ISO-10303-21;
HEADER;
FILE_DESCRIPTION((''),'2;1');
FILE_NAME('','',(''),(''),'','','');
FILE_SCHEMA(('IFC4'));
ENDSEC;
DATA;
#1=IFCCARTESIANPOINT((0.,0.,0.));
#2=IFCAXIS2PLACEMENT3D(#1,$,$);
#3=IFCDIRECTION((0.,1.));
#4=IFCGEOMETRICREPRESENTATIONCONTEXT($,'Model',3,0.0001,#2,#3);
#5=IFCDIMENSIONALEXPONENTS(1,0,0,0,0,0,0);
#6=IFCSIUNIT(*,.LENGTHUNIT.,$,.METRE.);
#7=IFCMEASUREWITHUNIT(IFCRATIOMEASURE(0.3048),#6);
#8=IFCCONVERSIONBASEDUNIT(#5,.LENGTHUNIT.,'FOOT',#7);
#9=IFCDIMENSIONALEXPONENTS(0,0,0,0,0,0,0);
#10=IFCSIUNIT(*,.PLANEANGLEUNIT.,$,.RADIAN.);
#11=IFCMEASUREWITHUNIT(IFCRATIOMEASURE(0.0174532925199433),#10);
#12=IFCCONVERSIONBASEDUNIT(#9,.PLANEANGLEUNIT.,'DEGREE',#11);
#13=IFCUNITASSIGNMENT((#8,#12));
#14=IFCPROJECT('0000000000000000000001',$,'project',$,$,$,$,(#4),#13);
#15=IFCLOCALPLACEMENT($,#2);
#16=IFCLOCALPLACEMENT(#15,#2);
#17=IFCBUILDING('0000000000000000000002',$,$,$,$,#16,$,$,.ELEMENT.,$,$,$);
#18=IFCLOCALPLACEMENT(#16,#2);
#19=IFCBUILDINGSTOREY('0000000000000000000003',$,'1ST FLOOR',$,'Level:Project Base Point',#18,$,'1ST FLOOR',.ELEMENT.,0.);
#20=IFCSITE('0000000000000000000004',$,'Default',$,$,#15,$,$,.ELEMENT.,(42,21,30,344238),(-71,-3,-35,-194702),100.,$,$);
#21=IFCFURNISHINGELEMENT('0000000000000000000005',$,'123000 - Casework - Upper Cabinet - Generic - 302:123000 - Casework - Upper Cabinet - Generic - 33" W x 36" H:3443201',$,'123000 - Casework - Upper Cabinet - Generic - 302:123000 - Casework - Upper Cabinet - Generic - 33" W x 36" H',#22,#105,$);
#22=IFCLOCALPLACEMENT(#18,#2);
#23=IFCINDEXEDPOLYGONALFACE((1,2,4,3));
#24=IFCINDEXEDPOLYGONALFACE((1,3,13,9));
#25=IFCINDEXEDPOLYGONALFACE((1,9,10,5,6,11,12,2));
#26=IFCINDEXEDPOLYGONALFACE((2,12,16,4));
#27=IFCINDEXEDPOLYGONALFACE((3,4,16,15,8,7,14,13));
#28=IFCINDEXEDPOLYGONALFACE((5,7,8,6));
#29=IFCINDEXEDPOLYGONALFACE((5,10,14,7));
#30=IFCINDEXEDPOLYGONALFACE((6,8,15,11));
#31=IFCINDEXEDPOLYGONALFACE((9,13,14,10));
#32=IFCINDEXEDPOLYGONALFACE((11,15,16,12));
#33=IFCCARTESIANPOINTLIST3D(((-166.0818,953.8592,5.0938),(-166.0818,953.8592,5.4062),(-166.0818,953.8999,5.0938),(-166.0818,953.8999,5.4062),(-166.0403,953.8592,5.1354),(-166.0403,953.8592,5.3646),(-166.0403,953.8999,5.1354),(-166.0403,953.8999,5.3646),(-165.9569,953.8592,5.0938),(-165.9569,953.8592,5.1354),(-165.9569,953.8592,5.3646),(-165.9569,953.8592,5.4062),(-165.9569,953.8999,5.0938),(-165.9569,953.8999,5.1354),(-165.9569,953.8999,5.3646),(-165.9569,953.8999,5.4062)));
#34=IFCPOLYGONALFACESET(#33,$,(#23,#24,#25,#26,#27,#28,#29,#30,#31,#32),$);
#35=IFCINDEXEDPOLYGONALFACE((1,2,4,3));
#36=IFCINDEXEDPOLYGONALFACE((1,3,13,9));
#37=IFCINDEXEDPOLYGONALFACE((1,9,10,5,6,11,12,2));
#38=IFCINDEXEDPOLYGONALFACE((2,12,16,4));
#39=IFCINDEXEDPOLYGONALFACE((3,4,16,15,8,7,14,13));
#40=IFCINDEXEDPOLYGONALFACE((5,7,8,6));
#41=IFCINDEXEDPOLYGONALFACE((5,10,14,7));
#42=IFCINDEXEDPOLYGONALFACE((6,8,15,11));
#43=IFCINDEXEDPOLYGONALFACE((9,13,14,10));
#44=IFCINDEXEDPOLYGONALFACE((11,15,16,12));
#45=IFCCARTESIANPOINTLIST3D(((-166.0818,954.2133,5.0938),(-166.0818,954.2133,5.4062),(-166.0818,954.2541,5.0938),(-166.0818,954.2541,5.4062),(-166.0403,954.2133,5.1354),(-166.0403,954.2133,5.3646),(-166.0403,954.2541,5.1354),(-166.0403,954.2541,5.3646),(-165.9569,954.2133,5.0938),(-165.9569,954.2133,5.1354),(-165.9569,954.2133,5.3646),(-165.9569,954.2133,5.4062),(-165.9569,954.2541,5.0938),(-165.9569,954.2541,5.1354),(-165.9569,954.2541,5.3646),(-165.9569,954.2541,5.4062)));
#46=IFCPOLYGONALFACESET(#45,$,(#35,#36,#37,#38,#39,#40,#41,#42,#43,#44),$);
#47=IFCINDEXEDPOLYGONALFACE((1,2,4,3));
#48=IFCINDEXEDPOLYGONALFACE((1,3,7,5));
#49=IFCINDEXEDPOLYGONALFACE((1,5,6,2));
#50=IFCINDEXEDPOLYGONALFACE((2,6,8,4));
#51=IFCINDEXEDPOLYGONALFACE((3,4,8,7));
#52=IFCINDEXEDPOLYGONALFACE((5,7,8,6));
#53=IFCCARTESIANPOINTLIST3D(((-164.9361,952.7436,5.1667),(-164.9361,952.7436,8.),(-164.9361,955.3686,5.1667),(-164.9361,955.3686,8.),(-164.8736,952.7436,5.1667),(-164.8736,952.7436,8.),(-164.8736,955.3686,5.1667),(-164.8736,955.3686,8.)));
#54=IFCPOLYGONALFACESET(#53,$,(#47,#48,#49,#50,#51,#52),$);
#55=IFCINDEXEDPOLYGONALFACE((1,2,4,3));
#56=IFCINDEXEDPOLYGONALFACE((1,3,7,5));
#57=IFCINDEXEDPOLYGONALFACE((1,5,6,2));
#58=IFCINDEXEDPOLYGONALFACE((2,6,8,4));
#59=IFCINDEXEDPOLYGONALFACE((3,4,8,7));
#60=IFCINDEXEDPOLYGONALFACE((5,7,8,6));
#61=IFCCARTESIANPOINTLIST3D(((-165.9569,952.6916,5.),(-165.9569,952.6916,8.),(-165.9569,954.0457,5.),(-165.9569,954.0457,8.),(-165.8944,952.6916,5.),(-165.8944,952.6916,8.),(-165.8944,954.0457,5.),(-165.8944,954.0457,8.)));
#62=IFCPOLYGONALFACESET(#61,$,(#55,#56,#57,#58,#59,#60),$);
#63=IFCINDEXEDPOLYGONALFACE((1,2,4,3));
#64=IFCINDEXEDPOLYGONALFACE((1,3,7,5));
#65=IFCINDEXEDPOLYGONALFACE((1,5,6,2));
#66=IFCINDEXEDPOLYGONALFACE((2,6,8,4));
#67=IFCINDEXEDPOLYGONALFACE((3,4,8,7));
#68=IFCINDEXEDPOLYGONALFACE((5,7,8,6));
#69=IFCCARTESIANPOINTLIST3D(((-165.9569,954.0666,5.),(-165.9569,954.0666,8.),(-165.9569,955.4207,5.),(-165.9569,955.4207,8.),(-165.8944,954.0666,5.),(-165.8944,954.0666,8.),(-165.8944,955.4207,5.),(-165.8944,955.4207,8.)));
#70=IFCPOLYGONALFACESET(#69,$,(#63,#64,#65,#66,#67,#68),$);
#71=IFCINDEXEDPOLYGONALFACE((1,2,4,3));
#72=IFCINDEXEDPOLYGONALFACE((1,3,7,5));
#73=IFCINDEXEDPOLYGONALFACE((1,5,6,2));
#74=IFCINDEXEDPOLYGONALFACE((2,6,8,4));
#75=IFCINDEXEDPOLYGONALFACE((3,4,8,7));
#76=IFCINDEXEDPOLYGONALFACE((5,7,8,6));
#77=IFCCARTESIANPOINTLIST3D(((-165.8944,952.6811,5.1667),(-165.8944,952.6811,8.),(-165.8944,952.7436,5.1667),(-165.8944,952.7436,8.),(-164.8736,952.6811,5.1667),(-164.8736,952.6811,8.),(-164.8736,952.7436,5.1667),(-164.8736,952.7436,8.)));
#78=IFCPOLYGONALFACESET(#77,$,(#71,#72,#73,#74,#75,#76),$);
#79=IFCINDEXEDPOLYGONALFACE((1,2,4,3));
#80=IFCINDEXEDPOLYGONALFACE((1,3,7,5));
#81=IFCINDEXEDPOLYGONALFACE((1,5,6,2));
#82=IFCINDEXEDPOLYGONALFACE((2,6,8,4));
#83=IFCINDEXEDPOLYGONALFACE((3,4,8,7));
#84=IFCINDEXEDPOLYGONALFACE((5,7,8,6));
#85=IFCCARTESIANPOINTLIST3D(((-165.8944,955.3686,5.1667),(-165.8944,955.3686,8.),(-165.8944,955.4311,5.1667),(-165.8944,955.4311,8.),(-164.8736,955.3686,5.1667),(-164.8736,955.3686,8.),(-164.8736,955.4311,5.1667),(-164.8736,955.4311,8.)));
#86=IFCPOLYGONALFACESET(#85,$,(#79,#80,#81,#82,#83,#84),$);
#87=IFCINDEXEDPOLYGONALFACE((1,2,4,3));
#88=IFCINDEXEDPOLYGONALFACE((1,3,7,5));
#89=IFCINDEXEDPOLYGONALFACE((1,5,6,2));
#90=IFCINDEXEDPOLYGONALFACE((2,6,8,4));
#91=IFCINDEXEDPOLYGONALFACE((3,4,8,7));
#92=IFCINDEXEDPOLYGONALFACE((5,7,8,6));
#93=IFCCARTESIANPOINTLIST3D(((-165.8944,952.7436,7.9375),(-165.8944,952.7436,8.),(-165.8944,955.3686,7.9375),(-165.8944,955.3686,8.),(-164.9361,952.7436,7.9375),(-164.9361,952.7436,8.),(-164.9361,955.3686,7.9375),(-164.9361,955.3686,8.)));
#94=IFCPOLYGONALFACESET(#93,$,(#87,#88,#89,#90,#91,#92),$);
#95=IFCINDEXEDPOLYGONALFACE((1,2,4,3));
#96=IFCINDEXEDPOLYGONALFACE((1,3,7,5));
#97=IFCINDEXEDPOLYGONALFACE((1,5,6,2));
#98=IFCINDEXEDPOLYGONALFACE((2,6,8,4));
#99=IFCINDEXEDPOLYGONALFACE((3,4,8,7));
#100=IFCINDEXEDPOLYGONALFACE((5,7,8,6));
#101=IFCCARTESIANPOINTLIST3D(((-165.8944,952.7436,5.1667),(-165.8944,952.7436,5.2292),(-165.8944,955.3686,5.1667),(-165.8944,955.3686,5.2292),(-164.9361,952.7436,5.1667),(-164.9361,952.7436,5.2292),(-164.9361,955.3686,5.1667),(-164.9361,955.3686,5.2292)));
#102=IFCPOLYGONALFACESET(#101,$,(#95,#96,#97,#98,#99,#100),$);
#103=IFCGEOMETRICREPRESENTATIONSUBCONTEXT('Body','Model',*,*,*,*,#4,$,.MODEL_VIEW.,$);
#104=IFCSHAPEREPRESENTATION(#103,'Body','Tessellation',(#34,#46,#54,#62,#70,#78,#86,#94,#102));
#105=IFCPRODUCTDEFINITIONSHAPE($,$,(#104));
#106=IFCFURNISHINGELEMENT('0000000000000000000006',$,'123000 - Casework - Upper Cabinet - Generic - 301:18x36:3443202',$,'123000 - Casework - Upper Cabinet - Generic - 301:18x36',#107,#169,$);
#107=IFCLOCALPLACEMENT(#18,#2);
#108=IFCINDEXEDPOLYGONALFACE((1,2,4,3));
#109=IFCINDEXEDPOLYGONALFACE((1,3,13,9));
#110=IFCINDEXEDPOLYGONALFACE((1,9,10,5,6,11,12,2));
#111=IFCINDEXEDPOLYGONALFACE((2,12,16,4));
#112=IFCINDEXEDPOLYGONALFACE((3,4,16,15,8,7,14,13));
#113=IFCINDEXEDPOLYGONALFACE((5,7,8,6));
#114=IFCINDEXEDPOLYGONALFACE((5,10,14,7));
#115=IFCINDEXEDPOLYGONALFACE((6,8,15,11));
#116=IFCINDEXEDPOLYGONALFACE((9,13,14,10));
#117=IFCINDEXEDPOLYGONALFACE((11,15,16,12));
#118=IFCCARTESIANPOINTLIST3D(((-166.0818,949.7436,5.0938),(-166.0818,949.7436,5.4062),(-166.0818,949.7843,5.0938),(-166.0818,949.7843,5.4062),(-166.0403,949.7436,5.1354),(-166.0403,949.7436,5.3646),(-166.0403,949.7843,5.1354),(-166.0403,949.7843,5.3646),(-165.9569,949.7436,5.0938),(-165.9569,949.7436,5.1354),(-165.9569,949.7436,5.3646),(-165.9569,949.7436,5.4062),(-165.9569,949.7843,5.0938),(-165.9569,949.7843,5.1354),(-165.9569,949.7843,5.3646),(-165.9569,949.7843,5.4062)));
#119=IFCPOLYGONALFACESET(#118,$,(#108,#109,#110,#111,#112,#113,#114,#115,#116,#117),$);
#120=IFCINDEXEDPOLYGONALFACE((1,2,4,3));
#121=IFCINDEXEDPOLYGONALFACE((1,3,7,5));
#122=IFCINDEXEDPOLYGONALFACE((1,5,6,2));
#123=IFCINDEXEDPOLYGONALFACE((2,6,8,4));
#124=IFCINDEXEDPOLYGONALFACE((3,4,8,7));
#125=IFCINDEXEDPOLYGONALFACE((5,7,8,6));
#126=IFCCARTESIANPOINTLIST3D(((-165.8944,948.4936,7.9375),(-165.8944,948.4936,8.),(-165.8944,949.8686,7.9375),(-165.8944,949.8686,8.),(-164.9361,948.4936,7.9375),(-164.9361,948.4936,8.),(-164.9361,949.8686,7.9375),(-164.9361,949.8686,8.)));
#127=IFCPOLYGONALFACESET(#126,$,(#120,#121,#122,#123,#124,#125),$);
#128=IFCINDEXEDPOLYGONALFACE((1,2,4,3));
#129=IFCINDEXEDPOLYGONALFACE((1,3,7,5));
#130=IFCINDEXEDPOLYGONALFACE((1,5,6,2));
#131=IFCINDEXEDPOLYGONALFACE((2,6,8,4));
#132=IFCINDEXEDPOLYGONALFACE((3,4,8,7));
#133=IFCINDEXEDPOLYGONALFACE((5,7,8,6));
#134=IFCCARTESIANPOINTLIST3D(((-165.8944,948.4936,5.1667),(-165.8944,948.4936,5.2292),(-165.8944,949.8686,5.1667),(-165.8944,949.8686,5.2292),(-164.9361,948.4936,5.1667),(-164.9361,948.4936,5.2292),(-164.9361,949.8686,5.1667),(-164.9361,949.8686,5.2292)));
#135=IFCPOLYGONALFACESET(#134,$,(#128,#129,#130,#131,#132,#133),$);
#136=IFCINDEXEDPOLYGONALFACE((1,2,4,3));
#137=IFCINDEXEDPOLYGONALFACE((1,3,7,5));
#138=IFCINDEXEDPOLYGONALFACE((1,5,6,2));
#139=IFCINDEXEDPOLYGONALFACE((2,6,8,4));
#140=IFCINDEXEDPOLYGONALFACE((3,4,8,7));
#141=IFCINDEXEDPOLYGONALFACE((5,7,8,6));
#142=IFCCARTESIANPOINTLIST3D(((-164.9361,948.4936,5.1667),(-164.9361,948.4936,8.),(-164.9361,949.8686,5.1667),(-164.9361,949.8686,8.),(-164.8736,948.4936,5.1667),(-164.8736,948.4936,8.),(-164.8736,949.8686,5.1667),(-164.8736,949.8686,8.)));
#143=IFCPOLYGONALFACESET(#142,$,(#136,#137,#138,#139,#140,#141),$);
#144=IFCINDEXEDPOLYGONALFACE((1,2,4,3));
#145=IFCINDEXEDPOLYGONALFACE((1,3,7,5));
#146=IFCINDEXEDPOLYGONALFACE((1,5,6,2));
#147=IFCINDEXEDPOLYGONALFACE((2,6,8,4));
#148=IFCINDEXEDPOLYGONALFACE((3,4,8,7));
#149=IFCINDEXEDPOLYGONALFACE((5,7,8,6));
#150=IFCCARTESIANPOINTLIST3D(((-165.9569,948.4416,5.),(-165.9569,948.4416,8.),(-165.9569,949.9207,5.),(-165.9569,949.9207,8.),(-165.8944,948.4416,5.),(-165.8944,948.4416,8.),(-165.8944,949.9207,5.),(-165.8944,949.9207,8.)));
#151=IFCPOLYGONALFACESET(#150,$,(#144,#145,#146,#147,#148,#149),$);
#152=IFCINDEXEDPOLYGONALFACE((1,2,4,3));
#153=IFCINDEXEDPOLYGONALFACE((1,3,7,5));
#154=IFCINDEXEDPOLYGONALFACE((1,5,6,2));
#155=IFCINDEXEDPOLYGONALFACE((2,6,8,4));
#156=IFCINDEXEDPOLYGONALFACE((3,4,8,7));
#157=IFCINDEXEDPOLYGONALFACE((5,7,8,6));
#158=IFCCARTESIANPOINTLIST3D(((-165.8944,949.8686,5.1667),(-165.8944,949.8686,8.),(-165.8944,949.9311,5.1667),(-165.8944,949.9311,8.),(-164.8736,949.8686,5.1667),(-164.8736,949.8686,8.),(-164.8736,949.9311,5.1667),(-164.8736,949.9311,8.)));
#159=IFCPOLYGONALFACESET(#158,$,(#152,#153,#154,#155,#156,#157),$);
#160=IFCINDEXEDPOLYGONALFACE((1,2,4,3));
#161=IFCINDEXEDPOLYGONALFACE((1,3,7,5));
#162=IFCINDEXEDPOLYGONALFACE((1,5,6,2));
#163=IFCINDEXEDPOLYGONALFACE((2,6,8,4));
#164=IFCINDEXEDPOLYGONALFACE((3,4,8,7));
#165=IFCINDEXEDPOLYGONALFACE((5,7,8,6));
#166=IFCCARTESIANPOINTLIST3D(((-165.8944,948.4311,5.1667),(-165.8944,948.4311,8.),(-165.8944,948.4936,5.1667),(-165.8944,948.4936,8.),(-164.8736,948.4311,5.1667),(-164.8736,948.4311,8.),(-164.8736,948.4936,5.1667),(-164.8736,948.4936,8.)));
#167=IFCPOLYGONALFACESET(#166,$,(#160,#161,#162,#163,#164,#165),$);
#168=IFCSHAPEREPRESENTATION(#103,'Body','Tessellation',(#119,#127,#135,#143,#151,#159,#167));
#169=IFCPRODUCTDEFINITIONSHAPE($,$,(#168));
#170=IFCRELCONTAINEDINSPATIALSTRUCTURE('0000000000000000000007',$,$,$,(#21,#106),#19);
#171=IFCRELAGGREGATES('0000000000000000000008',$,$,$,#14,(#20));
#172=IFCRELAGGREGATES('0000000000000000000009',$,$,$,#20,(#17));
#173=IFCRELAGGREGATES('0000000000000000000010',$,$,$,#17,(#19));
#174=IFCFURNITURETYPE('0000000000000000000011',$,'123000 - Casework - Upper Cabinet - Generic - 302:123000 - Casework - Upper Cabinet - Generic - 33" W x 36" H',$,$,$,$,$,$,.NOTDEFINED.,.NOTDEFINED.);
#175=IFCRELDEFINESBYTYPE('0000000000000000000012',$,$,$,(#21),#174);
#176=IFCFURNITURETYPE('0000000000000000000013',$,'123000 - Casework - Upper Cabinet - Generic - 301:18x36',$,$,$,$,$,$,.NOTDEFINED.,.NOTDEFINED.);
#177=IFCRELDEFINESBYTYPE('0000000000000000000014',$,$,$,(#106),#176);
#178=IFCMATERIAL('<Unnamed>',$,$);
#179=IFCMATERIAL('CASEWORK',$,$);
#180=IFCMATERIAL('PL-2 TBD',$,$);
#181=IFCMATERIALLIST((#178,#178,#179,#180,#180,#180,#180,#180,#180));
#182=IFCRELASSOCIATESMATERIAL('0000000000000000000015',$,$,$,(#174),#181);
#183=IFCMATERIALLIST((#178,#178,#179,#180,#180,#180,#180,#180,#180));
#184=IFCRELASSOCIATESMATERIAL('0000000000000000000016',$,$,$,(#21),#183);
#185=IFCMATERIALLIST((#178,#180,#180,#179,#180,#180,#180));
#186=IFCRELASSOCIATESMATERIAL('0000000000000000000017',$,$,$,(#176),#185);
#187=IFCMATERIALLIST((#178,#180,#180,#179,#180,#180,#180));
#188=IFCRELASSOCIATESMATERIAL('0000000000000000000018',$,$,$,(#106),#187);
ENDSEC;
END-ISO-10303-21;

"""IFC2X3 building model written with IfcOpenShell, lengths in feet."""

from ifc_helpers import new_model, entity, si_unit, converted_unit, direction, frame, frame_2d, origin, origin_2d_with_axis, place, context, subcontext, project, spatial, polyline, rectangle, outline, extrude, source, transform, mapped, material, material_list, type_object, type_shapes, element, save


model = new_model("IFC2X3")

# Units and contexts
model_context = context("Model", 3, precision=0.0001, world=origin(), true_north=direction((0.0, 1.0)))
body_context = subcontext(model_context, "Body", "Model", "MODEL_VIEW")
ifc_project = project(units=[converted_unit("LENGTHUNIT", "FOOT", entity("IfcRatioMeasure", 0.3048), si_unit("LENGTHUNIT", "METRE"), dimensions=[1, 0, 0, 0, 0, 0, 0]), converted_unit("PLANEANGLEUNIT", "DEGREE", entity("IfcRatioMeasure", 0.0174532925199433), si_unit("PLANEANGLEUNIT", "RADIAN"), dimensions=[0, 0, 0, 0, 0, 0, 0])], contexts=[model_context])

# Site, building, storey
site_placement = place(None, origin())
site = spatial("IfcSite", under=ifc_project, at=site_placement, Name="Default", CompositionType="ELEMENT", RefLatitude=(42, 21, 30, 344238), RefLongitude=(-71, -3, -35, -194702), RefElevation=100.0)
building_placement = place(site_placement, origin())
building = spatial("IfcBuilding", under=site, at=building_placement, CompositionType="ELEMENT")
storey_placement = place(building_placement, origin())
storey = spatial("IfcBuildingStorey", under=building, at=storey_placement, Name="1ST FLOOR", ObjectType="Level:Project Base Point", LongName="1ST FLOOR", CompositionType="ELEMENT", Elevation=0.0)

# Shared definitions
ifc_material_1 = material(Name="CASEWORK")

# Furnishing elements
ifc_material_2 = material(Name="<Unnamed>")
ifc_material_3 = material(Name="PL-2 TBD")
ifc_material_list_1 = material_list([ifc_material_2, ifc_material_2, ifc_material_1, ifc_material_3, ifc_material_3, ifc_material_3, ifc_material_3, ifc_material_3, ifc_material_3])
ifc_material_list_2 = material_list([ifc_material_2, ifc_material_2, ifc_material_1, ifc_material_3, ifc_material_3, ifc_material_3, ifc_material_3, ifc_material_3, ifc_material_3])
furniture_type_1 = type_object("IfcFurnitureType", Name="123000 - Casework - Upper Cabinet - Generic - 302:123000 - Casework - Upper Cabinet - Generic - 33\" W x 36\" H", material=ifc_material_list_2)
shared_shape_1 = source(origin(), body_context, "Body", "SweptSolid", [
    extrude(outline(polyline([(-0.0521, -0.1146), (-0.0521, -0.1562), (0.0729, -0.1562), (0.0729, 0.1562), (-0.0521, 0.1562), (-0.0521, 0.1146), (0.0313, 0.1146), (0.0313, -0.1146), (-0.0521, -0.1146)])), frame((1.178, 1.1354, 0.25), z_axis=(-1.0, 0.0, 0.0), x_axis=(0.0, 1.0, 0.0)), (0.0, 0.0, -1.0), 0.0407),
    extrude(outline(polyline([(-0.0521, -0.1146), (-0.0521, -0.1562), (0.0729, -0.1562), (0.0729, 0.1562), (-0.0521, 0.1562), (-0.0521, 0.1146), (0.0313, 0.1146), (0.0313, -0.1146), (-0.0521, -0.1146)])), frame((1.5322, 1.1354, 0.25), z_axis=(-1.0, 0.0, 0.0), x_axis=(0.0, 1.0, 0.0)), (0.0, 0.0, -1.0), 0.0407),
    extrude(rectangle(XDim=2.625, YDim=0.0625, at=frame_2d((0.0, 0.0), x_axis=(1.0, 0.0))), frame((1.375, 0.0313, 0.1667), z_axis=(0.0, 0.0, 1.0), x_axis=(-1.0, 0.0, 0.0)), (0.0, 0.0, 1.0), 2.8333),
    extrude(rectangle(XDim=1.3542, YDim=0.0625, at=origin_2d_with_axis()), frame((0.6875, 1.0521, 0.0)), (0.0, 0.0, 1.0), 3.0),
    extrude(rectangle(XDim=1.3542, YDim=0.0625, at=origin_2d_with_axis()), frame((2.0625, 1.0521, 0.0)), (0.0, 0.0, 1.0), 3.0),
    extrude(rectangle(XDim=1.0208, YDim=0.0625, at=origin_2d_with_axis()), frame((0.0312, 0.5104, 0.1667), z_axis=(0.0, 0.0, 1.0), x_axis=(0.0, 1.0, 0.0)), (0.0, 0.0, 1.0), 2.8333),
    extrude(rectangle(XDim=1.0208, YDim=0.0625, at=frame_2d((0.0, 0.0), x_axis=(1.0, 0.0))), frame((2.7188, 0.5104, 0.1667), z_axis=(0.0, 0.0, 1.0), x_axis=(0.0, 1.0, 0.0)), (0.0, 0.0, 1.0), 2.8333),
    extrude(rectangle(XDim=0.9583, YDim=2.625, at=frame_2d((0.0, 0.0), x_axis=(1.0, 0.0))), frame((1.375, 0.5417, 2.9375), z_axis=(0.0, 0.0, 1.0), x_axis=(0.0, 1.0, 0.0)), (0.0, 0.0, 1.0), 0.0625),
    extrude(rectangle(XDim=0.9583, YDim=2.625, at=frame_2d((0.0, 0.0), x_axis=(1.0, 0.0))), frame((1.375, 0.5417, 0.1667), z_axis=(0.0, 0.0, 1.0), x_axis=(0.0, 1.0, 0.0)), (0.0, 0.0, 1.0), 0.0625),
])
type_shapes(furniture_type_1, [shared_shape_1])
furnishing_1_placement = place(storey_placement, frame((-164.8736, 952.6811, 5.0), z_axis=(0.0, 0.0, 1.0), x_axis=(0.0, 1.0, 0.0)))
element("IfcFurnishingElement", 1, at=furnishing_1_placement, inside=storey, type_object=furniture_type_1, material=ifc_material_list_1, Name="123000 - Casework - Upper Cabinet - Generic - 302:123000 - Casework - Upper Cabinet - Generic - 33\" W x 36\" H:3443201", ObjectType="123000 - Casework - Upper Cabinet - Generic - 302:123000 - Casework - Upper Cabinet - Generic - 33\" W x 36\" H", context=body_context, shape_type="MappedRepresentation", body=[
    mapped(shared_shape_1, transform((0.0, 0.0, 0.0), scale=1.0)),
])
ifc_material_list_3 = material_list([ifc_material_2, ifc_material_3, ifc_material_3, ifc_material_1, ifc_material_3, ifc_material_3, ifc_material_3])
ifc_material_list_4 = material_list([ifc_material_2, ifc_material_3, ifc_material_3, ifc_material_1, ifc_material_3, ifc_material_3, ifc_material_3])
furniture_type_2 = type_object("IfcFurnitureType", Name="123000 - Casework - Upper Cabinet - Generic - 301:18x36", material=ifc_material_list_4)
shared_shape_2 = source(origin(), body_context, "Body", "SweptSolid", [
    extrude(outline(polyline([(0.1146, -0.0521), (0.1562, -0.0521), (0.1562, 0.0729), (-0.1562, 0.0729), (-0.1562, -0.0521), (-0.1146, -0.0521), (-0.1146, 0.0313), (0.1146, 0.0313), (0.1146, -0.0521)])), frame((0.1468, 0.0729, 0.25), z_axis=(1.0, 0.0, 0.0), x_axis=(0.0, 0.0, 1.0)), (0.0, 0.0, 1.0), 0.0407),
    extrude(rectangle(XDim=1.375, YDim=0.9583, at=frame_2d((0.0, 0.0), x_axis=(1.0, 0.0))), frame((0.75, 0.6666, 2.9375), z_axis=(0.0, 0.0, 1.0), x_axis=(-1.0, 0.0, 0.0)), (0.0, 0.0, 1.0), 0.0625),
    extrude(rectangle(XDim=1.375, YDim=0.9583, at=frame_2d((0.0, 0.0), x_axis=(1.0, 0.0))), frame((0.75, 0.6666, 0.1667), z_axis=(0.0, 0.0, 1.0), x_axis=(-1.0, 0.0, 0.0)), (0.0, 0.0, 1.0), 0.0625),
    extrude(rectangle(XDim=0.0625, YDim=1.375, at=origin_2d_with_axis()), frame((0.75, 1.177, 0.1667), z_axis=(0.0, 0.0, 1.0), x_axis=(0.0, 1.0, 0.0)), (0.0, 0.0, 1.0), 2.8333),
    extrude(rectangle(XDim=0.0625, YDim=1.4792, at=origin_2d_with_axis()), frame((0.75, 0.1562, 0.0), z_axis=(0.0, 0.0, 1.0), x_axis=(0.0, -1.0, 0.0)), (0.0, 0.0, 1.0), 3.0),
    extrude(rectangle(XDim=0.0625, YDim=1.0208, at=origin_2d_with_axis()), frame((0.0312, 0.6979, 0.1667), z_axis=(0.0, 0.0, 1.0), x_axis=(-1.0, 0.0, 0.0)), (0.0, 0.0, 1.0), 2.8333),
    extrude(rectangle(XDim=0.0625, YDim=1.0208, at=origin_2d_with_axis()), frame((1.4688, 0.6979, 0.1667), z_axis=(0.0, 0.0, 1.0), x_axis=(-1.0, 0.0, 0.0)), (0.0, 0.0, 1.0), 2.8333),
])
type_shapes(furniture_type_2, [shared_shape_2])
furnishing_2_placement = place(storey_placement, frame((-166.0818, 949.9311, 5.0), z_axis=(0.0, 0.0, 1.0), x_axis=(0.0, -1.0, 0.0)))
element("IfcFurnishingElement", 2, at=furnishing_2_placement, inside=storey, type_object=furniture_type_2, material=ifc_material_list_3, Name="123000 - Casework - Upper Cabinet - Generic - 301:18x36:3443202", ObjectType="123000 - Casework - Upper Cabinet - Generic - 301:18x36", context=body_context, shape_type="MappedRepresentation", body=[
    mapped(shared_shape_2, transform((0.0, 0.0, 0.0), scale=1.0)),
])

save(model, "model.ifc")
